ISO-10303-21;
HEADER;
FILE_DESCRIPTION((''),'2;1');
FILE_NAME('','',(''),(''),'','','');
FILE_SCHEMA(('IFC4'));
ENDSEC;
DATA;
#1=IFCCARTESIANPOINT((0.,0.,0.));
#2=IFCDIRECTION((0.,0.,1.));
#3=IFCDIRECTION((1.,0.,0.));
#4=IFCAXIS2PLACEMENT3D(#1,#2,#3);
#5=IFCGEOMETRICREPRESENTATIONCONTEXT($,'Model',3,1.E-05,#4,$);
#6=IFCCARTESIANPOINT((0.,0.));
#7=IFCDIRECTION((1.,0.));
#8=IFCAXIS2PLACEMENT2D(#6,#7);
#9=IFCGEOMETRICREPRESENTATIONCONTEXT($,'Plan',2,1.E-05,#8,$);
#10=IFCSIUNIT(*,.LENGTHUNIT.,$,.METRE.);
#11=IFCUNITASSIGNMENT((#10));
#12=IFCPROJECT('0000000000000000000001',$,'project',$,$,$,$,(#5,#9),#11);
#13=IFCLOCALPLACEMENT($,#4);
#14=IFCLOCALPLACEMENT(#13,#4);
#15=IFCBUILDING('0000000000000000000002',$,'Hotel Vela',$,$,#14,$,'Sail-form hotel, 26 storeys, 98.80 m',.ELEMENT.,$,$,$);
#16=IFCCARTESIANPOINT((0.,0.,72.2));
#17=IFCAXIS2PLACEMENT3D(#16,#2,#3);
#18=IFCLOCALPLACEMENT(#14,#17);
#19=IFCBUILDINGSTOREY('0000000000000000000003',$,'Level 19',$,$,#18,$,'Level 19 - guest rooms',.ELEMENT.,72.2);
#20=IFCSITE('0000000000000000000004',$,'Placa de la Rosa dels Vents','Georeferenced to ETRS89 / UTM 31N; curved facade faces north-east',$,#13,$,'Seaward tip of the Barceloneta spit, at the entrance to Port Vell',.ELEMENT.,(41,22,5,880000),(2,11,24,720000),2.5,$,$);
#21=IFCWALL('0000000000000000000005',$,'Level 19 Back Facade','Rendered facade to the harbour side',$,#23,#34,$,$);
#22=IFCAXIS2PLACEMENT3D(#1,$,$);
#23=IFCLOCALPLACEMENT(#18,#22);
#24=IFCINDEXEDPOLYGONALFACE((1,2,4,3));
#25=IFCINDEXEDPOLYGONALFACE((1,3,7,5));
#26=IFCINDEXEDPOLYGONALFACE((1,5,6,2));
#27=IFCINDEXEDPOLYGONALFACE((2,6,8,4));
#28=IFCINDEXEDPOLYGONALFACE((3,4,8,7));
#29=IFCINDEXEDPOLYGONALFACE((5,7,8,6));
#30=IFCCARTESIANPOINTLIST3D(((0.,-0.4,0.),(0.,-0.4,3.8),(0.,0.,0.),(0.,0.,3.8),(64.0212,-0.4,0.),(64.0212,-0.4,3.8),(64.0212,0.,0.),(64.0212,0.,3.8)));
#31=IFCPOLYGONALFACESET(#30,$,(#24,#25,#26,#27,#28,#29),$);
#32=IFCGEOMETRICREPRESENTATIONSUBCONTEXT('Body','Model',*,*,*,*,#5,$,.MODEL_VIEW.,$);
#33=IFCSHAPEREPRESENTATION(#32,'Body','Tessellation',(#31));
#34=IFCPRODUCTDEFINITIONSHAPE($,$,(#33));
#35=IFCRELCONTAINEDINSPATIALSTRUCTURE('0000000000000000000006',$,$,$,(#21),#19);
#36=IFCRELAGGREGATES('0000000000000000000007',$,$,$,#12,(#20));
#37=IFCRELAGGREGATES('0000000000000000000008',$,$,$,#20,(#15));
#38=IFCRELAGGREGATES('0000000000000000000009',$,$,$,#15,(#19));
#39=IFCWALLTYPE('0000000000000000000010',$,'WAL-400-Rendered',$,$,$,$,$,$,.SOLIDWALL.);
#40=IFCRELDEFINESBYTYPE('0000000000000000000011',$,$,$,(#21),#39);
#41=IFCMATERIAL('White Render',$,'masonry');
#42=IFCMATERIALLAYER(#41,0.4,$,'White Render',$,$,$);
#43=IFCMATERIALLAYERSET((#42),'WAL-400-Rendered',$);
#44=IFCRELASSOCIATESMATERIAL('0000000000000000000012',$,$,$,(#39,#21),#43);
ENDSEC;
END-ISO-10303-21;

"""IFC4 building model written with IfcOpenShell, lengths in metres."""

from ifc_helpers import new_model, si_unit, frame, origin_with_axes, origin_2d_with_axis, place, context, subcontext, project, spatial, line, indexed_curve, outline, extrude, material, layer, layer_set, layer_usage, type_object, element, save


model = new_model("IFC4")

# Units and contexts
model_context = context("Model", 3, precision=1e-05, world=origin_with_axes())
plan_context = context("Plan", 2, precision=1e-05, world=origin_2d_with_axis())
body_context = subcontext(model_context, "Body", "Model", "MODEL_VIEW")
ifc_project = project(units=[si_unit("LENGTHUNIT", "METRE")], contexts=[model_context, plan_context])

# Site, building, storey
site_placement = place(None, origin_with_axes())
site = spatial("IfcSite", under=ifc_project, at=site_placement, Name="Placa de la Rosa dels Vents", Description="Georeferenced to ETRS89 / UTM 31N; curved facade faces north-east", LongName="Seaward tip of the Barceloneta spit, at the entrance to Port Vell", CompositionType="ELEMENT", RefLatitude=(41, 22, 5, 880000), RefLongitude=(2, 11, 24, 720000), RefElevation=2.5)
building_placement = place(site_placement, origin_with_axes())
building = spatial("IfcBuilding", under=site, at=building_placement, Name="Hotel Vela", LongName="Sail-form hotel, 26 storeys, 98.80 m", CompositionType="ELEMENT")
storey_placement = place(building_placement, frame((0.0, 0.0, 72.2), z_axis=(0.0, 0.0, 1.0), x_axis=(1.0, 0.0, 0.0)))
storey = spatial("IfcBuildingStorey", under=building, at=storey_placement, Name="Level 19", LongName="Level 19 - guest rooms", CompositionType="ELEMENT", Elevation=72.2)

# Wall
ifc_material_1 = material(Name="White Render", Category="masonry")
ifc_layer_1 = layer(ifc_material_1, 0.4, Name="White Render")
ifc_layer_set_1 = layer_set([ifc_layer_1], Name="WAL-400-Rendered")
ifc_layer_usage_1 = layer_usage(ifc_layer_set_1, "AXIS2", "POSITIVE", 0.0)
wall_type = type_object("IfcWallType", Name="WAL-400-Rendered", PredefinedType="SOLIDWALL", material=ifc_layer_set_1)
wall_placement = place(storey_placement, frame((0.0, -0.4, 0.0), z_axis=(0.0, 0.0, 1.0), x_axis=(1.0, 0.0, 0.0)))
element("IfcWall", 1, at=wall_placement, inside=storey, type_object=wall_type, material=ifc_layer_usage_1, Name="Level 19 Back Facade", Description="Rendered facade to the harbour side", context=body_context, shape_type="SweptSolid", body=[
    extrude(outline(indexed_curve([(0.0, 0.0), (64.0212, 0.0), (64.0212, 0.4), (0.0, 0.4)], segments=[line(1, 2, 3, 4, 1)])), origin_with_axes(), (0.0, 0.0, 1.0), 3.8),
])

save(model, "model.ifc")
